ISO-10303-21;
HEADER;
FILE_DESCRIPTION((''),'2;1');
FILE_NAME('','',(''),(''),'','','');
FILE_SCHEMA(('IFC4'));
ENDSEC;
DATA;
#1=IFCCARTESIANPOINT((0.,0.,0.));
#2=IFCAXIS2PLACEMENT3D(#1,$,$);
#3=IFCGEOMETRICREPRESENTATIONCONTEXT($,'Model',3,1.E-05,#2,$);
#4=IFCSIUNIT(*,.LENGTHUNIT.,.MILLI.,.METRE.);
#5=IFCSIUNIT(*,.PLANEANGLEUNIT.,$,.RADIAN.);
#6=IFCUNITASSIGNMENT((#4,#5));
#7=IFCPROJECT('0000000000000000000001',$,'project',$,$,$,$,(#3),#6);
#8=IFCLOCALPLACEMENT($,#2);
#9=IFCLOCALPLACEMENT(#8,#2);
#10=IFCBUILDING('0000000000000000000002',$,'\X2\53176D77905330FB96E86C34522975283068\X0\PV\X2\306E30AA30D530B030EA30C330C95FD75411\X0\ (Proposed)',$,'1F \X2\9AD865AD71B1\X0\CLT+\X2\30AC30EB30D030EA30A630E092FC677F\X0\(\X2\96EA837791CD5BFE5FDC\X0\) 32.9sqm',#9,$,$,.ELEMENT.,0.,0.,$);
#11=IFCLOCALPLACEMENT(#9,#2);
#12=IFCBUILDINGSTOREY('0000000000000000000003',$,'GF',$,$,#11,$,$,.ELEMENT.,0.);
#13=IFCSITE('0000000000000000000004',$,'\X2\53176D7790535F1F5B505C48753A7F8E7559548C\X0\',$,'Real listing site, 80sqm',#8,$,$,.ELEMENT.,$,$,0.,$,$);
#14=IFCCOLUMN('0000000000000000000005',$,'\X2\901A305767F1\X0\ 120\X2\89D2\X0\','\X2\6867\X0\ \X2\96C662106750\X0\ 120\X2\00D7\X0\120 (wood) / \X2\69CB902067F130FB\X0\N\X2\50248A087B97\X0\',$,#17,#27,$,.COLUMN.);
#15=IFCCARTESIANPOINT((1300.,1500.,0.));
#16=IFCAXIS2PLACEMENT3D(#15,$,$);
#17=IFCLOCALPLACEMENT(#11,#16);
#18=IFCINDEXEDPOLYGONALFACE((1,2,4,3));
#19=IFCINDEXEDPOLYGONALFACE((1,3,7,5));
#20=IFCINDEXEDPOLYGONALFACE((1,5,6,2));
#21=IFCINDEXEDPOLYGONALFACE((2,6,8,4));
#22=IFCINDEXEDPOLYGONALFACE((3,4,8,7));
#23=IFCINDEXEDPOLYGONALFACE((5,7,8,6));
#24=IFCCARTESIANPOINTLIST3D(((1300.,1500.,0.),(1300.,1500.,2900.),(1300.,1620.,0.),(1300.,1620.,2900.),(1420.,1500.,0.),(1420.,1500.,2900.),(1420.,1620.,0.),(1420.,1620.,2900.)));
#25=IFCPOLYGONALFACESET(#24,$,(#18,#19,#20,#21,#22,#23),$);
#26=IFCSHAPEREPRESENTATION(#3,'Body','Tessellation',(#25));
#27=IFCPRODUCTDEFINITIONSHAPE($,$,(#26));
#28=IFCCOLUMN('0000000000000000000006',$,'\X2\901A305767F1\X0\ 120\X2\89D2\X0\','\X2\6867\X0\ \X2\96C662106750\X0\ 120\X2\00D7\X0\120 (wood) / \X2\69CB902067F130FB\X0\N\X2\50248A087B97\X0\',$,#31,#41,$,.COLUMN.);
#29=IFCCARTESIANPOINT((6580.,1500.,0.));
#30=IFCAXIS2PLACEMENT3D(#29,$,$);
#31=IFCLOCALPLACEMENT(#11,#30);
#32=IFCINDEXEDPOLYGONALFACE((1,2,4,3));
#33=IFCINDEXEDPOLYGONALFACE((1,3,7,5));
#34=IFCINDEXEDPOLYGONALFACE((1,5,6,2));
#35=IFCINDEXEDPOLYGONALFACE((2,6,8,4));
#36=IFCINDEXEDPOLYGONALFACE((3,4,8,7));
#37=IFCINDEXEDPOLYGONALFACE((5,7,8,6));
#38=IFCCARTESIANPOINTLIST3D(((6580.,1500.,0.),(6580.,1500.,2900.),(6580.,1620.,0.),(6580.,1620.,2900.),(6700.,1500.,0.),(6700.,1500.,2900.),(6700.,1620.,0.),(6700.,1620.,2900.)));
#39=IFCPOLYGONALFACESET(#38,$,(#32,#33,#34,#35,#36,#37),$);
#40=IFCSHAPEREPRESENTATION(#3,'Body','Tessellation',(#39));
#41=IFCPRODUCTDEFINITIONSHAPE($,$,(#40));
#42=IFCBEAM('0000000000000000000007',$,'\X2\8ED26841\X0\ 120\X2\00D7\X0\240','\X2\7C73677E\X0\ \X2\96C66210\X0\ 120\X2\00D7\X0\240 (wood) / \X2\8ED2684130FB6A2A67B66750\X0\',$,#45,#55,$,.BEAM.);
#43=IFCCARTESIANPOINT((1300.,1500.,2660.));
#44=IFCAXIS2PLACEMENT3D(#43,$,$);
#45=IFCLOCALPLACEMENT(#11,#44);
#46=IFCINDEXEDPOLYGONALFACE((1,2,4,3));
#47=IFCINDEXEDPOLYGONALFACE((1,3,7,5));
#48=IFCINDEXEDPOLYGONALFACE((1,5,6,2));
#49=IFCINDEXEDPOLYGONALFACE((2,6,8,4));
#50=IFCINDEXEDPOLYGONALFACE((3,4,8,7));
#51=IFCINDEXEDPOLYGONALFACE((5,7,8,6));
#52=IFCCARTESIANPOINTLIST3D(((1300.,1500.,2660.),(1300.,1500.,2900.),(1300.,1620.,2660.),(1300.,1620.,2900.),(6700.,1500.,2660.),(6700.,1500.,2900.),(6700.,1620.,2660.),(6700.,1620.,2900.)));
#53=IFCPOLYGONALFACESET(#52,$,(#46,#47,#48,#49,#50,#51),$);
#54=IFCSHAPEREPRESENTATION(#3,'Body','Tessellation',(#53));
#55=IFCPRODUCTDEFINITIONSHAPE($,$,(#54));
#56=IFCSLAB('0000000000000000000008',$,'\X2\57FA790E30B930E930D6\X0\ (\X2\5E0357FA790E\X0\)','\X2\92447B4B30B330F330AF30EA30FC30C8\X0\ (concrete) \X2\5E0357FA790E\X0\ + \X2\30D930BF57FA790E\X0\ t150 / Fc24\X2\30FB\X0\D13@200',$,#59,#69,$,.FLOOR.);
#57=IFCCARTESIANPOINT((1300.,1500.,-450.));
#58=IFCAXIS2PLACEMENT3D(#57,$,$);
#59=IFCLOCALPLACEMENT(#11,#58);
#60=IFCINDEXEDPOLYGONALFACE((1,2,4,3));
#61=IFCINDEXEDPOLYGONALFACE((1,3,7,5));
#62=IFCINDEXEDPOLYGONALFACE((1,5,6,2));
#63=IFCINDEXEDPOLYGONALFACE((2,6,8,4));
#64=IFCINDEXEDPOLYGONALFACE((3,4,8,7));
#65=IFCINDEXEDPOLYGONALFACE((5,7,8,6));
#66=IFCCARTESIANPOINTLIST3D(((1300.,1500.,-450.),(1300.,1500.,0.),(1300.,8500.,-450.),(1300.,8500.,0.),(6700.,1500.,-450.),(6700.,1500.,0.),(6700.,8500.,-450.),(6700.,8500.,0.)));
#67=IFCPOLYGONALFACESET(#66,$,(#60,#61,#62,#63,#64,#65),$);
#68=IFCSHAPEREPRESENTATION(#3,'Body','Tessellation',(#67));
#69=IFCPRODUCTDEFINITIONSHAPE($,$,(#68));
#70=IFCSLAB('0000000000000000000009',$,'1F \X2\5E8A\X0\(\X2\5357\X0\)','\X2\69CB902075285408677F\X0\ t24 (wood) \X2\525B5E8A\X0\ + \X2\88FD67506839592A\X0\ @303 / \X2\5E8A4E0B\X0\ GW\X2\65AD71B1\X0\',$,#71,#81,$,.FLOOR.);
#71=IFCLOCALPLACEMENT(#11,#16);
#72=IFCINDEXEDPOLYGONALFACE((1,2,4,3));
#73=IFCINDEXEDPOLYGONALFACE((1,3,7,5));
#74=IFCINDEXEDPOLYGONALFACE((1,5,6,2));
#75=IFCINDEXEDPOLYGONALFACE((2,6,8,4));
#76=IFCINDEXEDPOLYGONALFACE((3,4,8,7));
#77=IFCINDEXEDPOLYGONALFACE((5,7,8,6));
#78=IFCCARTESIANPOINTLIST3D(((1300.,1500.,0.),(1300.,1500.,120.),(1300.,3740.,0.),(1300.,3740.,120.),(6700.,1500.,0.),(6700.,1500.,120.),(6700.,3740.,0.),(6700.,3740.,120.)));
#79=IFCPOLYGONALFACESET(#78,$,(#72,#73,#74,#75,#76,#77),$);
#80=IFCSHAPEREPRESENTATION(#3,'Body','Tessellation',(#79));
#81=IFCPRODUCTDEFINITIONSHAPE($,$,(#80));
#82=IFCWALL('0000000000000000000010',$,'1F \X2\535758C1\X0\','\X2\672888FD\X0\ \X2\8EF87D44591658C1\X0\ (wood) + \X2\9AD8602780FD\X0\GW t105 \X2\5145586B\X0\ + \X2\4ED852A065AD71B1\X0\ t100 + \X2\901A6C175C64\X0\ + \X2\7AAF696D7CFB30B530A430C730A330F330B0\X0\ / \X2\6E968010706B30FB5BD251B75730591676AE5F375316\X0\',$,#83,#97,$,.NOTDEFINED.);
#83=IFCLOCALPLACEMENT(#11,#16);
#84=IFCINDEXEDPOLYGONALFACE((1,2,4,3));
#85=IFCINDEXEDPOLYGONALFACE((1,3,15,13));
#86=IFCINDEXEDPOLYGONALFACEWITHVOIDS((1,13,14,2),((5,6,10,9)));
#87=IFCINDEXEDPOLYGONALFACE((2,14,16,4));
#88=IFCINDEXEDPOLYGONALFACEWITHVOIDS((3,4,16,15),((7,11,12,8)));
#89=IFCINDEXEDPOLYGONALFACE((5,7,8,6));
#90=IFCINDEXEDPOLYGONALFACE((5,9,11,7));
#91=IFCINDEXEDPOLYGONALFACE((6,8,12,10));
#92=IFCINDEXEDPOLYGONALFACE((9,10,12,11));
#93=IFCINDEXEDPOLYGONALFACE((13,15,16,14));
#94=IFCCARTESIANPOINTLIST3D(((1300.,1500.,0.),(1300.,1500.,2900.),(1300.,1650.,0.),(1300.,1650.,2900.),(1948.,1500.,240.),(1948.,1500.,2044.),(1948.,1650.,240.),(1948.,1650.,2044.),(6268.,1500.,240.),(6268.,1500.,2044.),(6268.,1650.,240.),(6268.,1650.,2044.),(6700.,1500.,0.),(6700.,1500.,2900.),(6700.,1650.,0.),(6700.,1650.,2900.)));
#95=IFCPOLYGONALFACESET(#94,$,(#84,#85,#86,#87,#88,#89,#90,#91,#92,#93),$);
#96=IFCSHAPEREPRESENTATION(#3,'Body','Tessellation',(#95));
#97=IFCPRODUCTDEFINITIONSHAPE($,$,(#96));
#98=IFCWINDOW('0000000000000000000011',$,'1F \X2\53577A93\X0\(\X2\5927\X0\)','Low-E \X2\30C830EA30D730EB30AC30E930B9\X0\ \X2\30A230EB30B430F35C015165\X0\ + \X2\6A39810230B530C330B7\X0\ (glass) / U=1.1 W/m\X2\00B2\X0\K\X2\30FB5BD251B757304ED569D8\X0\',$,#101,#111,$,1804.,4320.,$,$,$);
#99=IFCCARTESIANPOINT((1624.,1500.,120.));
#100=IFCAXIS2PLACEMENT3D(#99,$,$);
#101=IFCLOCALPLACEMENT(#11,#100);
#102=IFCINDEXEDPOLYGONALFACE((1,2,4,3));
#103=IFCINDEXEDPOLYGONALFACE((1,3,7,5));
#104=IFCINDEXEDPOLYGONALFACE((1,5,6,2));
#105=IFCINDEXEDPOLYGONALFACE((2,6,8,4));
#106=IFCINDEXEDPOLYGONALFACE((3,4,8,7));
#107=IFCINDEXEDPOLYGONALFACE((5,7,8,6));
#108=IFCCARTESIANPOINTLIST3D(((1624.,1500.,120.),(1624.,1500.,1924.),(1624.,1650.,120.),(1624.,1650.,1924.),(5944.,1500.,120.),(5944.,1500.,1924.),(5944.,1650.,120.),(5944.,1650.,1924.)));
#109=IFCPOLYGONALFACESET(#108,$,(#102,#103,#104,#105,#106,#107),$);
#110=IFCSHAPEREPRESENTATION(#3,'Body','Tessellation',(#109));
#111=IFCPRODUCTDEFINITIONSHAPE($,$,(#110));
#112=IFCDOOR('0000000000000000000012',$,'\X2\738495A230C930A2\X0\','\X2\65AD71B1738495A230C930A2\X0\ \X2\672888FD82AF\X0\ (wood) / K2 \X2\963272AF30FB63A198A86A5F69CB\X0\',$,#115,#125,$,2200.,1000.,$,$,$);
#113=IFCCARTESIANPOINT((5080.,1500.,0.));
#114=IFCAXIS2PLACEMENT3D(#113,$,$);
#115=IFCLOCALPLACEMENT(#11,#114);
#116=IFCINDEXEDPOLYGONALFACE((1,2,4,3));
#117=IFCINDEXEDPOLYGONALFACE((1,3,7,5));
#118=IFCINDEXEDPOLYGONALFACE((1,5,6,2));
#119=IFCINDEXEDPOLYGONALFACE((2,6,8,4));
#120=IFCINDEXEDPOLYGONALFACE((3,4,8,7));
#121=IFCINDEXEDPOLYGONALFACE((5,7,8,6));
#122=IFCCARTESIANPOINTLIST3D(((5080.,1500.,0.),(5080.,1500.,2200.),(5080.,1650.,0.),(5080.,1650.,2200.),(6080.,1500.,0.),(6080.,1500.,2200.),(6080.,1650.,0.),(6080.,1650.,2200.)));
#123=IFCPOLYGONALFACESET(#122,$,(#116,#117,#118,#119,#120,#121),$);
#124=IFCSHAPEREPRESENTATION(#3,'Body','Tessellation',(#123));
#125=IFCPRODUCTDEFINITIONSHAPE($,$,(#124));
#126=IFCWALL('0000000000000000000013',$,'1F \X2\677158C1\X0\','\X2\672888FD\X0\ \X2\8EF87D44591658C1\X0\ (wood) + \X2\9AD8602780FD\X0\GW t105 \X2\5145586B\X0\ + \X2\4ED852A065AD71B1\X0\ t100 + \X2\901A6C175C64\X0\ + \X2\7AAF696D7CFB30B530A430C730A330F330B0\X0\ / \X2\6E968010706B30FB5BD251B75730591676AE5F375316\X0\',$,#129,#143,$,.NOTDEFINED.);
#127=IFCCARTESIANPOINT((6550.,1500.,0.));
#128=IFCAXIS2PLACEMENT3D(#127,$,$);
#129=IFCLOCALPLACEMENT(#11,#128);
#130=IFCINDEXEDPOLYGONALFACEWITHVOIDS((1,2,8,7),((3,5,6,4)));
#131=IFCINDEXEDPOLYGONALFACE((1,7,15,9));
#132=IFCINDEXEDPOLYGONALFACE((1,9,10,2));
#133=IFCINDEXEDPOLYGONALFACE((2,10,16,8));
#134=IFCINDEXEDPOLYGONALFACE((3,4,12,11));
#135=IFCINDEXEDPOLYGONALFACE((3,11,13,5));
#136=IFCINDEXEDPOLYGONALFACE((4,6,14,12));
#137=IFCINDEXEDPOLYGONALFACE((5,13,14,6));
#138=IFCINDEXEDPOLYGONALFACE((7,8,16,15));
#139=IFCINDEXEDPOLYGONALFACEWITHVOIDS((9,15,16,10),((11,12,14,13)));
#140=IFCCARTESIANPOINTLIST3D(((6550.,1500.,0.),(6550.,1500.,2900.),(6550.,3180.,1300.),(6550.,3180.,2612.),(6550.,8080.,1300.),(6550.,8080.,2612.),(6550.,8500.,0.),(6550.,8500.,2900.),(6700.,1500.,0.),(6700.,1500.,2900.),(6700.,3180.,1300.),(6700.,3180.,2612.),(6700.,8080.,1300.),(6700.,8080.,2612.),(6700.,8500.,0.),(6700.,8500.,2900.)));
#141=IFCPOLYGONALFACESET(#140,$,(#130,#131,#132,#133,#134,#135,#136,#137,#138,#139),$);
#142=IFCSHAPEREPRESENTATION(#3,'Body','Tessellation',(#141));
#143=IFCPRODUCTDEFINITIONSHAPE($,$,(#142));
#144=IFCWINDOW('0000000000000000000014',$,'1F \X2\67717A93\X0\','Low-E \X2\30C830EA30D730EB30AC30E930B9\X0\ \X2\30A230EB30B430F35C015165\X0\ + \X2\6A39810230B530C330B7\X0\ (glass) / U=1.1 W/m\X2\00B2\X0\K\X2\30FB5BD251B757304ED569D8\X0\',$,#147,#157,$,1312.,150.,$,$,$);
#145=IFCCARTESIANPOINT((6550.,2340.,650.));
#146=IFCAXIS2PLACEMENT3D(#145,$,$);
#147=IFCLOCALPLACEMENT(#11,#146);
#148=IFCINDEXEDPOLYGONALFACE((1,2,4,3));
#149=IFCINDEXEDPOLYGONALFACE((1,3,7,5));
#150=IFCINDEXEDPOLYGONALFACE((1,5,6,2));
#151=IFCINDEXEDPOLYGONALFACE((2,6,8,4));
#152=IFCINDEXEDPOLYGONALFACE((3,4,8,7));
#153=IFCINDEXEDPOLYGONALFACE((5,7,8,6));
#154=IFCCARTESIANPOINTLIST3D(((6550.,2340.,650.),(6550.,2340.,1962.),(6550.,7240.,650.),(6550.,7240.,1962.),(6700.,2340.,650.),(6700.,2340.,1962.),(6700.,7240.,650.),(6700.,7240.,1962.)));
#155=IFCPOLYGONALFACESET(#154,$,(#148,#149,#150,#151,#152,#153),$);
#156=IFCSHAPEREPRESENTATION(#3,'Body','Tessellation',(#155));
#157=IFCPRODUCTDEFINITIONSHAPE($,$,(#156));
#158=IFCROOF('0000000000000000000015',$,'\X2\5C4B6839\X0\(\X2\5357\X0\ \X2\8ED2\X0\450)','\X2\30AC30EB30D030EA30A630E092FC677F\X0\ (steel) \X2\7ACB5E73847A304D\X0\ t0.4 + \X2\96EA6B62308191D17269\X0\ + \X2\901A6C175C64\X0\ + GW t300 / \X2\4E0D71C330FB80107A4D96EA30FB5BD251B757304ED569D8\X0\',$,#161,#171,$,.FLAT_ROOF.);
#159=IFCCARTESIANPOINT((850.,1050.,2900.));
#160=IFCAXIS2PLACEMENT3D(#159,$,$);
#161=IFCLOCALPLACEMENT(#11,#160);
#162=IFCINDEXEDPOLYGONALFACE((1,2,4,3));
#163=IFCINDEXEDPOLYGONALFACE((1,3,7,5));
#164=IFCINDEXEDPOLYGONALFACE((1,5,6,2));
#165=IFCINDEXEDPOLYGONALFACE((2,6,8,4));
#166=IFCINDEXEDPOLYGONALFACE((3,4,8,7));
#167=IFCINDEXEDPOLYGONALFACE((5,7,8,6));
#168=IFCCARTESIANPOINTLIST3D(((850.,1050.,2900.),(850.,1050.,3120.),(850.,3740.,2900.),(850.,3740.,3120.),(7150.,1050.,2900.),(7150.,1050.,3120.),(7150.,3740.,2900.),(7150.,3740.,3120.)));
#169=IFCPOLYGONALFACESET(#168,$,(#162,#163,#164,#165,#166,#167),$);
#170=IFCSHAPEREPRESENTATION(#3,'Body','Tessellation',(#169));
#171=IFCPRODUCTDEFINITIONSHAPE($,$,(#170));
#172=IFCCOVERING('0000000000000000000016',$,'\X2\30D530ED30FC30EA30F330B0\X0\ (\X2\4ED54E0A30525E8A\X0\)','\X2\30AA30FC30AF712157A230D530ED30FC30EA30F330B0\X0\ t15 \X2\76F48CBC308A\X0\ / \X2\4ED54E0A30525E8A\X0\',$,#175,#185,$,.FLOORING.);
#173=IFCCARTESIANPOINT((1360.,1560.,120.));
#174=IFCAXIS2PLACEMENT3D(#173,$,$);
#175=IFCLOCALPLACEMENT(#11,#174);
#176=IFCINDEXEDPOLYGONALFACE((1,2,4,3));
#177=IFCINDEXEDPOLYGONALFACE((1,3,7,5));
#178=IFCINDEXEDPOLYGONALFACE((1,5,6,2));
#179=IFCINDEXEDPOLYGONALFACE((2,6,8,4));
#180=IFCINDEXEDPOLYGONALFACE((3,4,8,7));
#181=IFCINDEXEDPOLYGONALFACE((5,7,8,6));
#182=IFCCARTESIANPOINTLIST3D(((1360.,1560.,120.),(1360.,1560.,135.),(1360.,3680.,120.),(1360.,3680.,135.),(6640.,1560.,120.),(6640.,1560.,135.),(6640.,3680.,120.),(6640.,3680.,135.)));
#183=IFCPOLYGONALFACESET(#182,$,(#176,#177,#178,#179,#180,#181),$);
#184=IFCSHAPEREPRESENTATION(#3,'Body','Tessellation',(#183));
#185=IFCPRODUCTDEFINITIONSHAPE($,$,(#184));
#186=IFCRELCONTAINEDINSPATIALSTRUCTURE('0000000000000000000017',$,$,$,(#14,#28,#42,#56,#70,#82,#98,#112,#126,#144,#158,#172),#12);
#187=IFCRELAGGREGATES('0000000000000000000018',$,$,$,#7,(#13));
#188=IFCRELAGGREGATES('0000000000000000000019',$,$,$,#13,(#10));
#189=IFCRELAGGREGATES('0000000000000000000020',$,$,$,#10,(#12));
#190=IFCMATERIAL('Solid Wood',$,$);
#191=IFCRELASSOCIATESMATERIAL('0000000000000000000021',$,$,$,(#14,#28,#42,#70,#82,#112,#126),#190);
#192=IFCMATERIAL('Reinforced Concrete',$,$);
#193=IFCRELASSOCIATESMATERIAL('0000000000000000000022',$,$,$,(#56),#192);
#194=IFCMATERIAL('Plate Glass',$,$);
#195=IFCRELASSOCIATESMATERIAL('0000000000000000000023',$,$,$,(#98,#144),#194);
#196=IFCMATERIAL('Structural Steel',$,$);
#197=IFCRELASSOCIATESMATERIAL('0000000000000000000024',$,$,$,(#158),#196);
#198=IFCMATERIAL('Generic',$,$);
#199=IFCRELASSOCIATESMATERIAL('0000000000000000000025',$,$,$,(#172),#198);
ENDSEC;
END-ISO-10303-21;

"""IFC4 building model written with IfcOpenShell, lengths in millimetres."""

from ifc_helpers import new_model, si_unit, frame, frame_2d, origin, place, context, project, spatial, rectangle, extrude, material, element, fill, save


model = new_model("IFC4")

# Units and contexts
model_context = context("Model", 3, precision=1e-05, world=origin())
ifc_project = project(units=[si_unit("LENGTHUNIT", "METRE", prefix="MILLI"), si_unit("PLANEANGLEUNIT", "RADIAN")], contexts=[model_context])

# Site, building, storey
site_placement = place(None, origin())
site = spatial("IfcSite", under=ifc_project, at=site_placement, Name="北海道弟子屈町美留和", ObjectType="Real listing site, 80sqm", CompositionType="ELEMENT", RefElevation=0.0)
building_placement = place(site_placement, origin())
building = spatial("IfcBuilding", under=site, at=building_placement, Name="北海道・雨水利用とPVのオフグリッド志向 (Proposed)", ObjectType="1F 高断熱CLT+ガルバリウム鋼板(雪荷重対応) 32.9sqm", CompositionType="ELEMENT", ElevationOfRefHeight=0.0, ElevationOfTerrain=0.0)
storey_placement = place(building_placement, origin())
storey = spatial("IfcBuildingStorey", under=building, at=storey_placement, Name="GF", CompositionType="ELEMENT", Elevation=0.0)

# Columns
ifc_material_1 = material(Name="Solid Wood")
column_1_placement = place(storey_placement, frame((1300.0, 1500.0, 0.0)))
element("IfcColumn", 1, at=column_1_placement, inside=storey, material=ifc_material_1, Name="通し柱 120角", Description="桧 集成材 120×120 (wood) / 構造柱・N値計算", PredefinedType="COLUMN", context=model_context, shape_type="SweptSolid", body=[
    extrude(rectangle(XDim=120.0, YDim=120.0, at=frame_2d((60.0, 60.0))), frame((1300.0, 1500.0, 0.0)), (0.0, 0.0, 1.0), 2900.0),
])
column_2_placement = place(storey_placement, frame((6580.0, 1500.0, 0.0)))
element("IfcColumn", 2, at=column_2_placement, inside=storey, material=ifc_material_1, Name="通し柱 120角", Description="桧 集成材 120×120 (wood) / 構造柱・N値計算", PredefinedType="COLUMN", context=model_context, shape_type="SweptSolid", body=[
    extrude(rectangle(XDim=120.0, YDim=120.0, at=frame_2d((60.0, 60.0))), frame((6580.0, 1500.0, 0.0)), (0.0, 0.0, 1.0), 2900.0),
])

# Beam
beam_1_placement = place(storey_placement, frame((1300.0, 1500.0, 2660.0)))
element("IfcBeam", 3, at=beam_1_placement, inside=storey, material=ifc_material_1, Name="軒桁 120×240", Description="米松 集成 120×240 (wood) / 軒桁・横架材", PredefinedType="BEAM", context=model_context, shape_type="SweptSolid", body=[
    extrude(rectangle(XDim=5400.0, YDim=120.0, at=frame_2d((2700.0, 60.0))), frame((1300.0, 1500.0, 2660.0)), (0.0, 0.0, 1.0), 240.0),
])

# Slabs
ifc_material_2 = material(Name="Reinforced Concrete")
slab_1_placement = place(storey_placement, frame((1300.0, 1500.0, -450.0)))
element("IfcSlab", 4, at=slab_1_placement, inside=storey, material=ifc_material_2, Name="基礎スラブ (布基礎)", Description="鉄筋コンクリート (concrete) 布基礎 + ベタ基礎 t150 / Fc24・D13@200", PredefinedType="FLOOR", context=model_context, shape_type="SweptSolid", body=[
    extrude(rectangle(XDim=5400.0, YDim=7000.0, at=frame_2d((2700.0, 3500.0))), frame((1300.0, 1500.0, -450.0)), (0.0, 0.0, 1.0), 450.0),
])
slab_2_placement = place(storey_placement, frame((1300.0, 1500.0, 0.0)))
element("IfcSlab", 5, at=slab_2_placement, inside=storey, material=ifc_material_1, Name="1F 床(南)", Description="構造用合板 t24 (wood) 剛床 + 製材根太 @303 / 床下 GW断熱", PredefinedType="FLOOR", context=model_context, shape_type="SweptSolid", body=[
    extrude(rectangle(XDim=5400.0, YDim=2240.0, at=frame_2d((2700.0, 1120.0))), frame((1300.0, 1500.0, 0.0)), (0.0, 0.0, 1.0), 120.0),
])

# Wall, openings, window, door
wall_1_placement = place(storey_placement, frame((1300.0, 1500.0, 0.0)))
wall_1 = element("IfcWall", 6, at=wall_1_placement, inside=storey, material=ifc_material_1, Name="1F 南壁", Description="木製 軸組外壁 (wood) + 高性能GW t105 充填 + 付加断熱 t100 + 通気層 + 窯業系サイディング / 準耐火・寒冷地外皮強化", PredefinedType="NOTDEFINED", context=model_context, shape_type="SweptSolid", body=[
    extrude(rectangle(XDim=5400.0, YDim=150.0, at=frame_2d((2700.0, 75.0))), frame((1300.0, 1500.0, 0.0)), (0.0, 0.0, 1.0), 2900.0),
])
opening_1_placement = place(storey_placement, frame((1624.0, 1500.0, 120.0)))
opening_1 = element("IfcOpeningElement", 7, at=opening_1_placement, cuts=wall_1, PredefinedType="NOTDEFINED", context=model_context, shape_type="SweptSolid", body=[
    extrude(rectangle(XDim=4320.0, YDim=150.0, at=frame_2d((2160.0, 75.0))), frame((1624.0, 1500.0, 120.0)), (0.0, 0.0, 1.0), 1804.0),
])
opening_2_placement = place(storey_placement, frame((5080.0, 1500.0, 0.0)))
opening_2 = element("IfcOpeningElement", 8, at=opening_2_placement, cuts=wall_1, PredefinedType="NOTDEFINED", context=model_context, shape_type="SweptSolid", body=[
    extrude(rectangle(XDim=1000.0, YDim=150.0, at=frame_2d((500.0, 75.0))), frame((5080.0, 1500.0, 0.0)), (0.0, 0.0, 1.0), 2200.0),
])
ifc_material_3 = material(Name="Plate Glass")
window_1_placement = place(storey_placement, frame((1624.0, 1500.0, 120.0)))
window_1 = element("IfcWindow", 9, at=window_1_placement, inside=storey, material=ifc_material_3, Name="1F 南窓(大)", Description="Low-E トリプルガラス アルゴン封入 + 樹脂サッシ (glass) / U=1.1 W/m²K・寒冷地仕様", OverallHeight=1804.0, OverallWidth=4320.0, context=model_context, shape_type="SweptSolid", body=[
    extrude(rectangle(XDim=4320.0, YDim=150.0, at=frame_2d((2160.0, 75.0))), frame((1624.0, 1500.0, 120.0)), (0.0, 0.0, 1.0), 1804.0),
])
fill(opening_1, window_1)
door_placement = place(storey_placement, frame((5080.0, 1500.0, 0.0)))
door = element("IfcDoor", 10, at=door_placement, inside=storey, material=ifc_material_1, Name="玄関ドア", Description="断熱玄関ドア 木製芯 (wood) / K2 防犯・採風機構", OverallHeight=2200.0, OverallWidth=1000.0, context=model_context, shape_type="SweptSolid", body=[
    extrude(rectangle(XDim=1000.0, YDim=150.0, at=frame_2d((500.0, 75.0))), frame((5080.0, 1500.0, 0.0)), (0.0, 0.0, 1.0), 2200.0),
])
fill(opening_2, door)

# Wall, opening, window
wall_2_placement = place(storey_placement, frame((6550.0, 1500.0, 0.0)))
wall_2 = element("IfcWall", 11, at=wall_2_placement, inside=storey, material=ifc_material_1, Name="1F 東壁", Description="木製 軸組外壁 (wood) + 高性能GW t105 充填 + 付加断熱 t100 + 通気層 + 窯業系サイディング / 準耐火・寒冷地外皮強化", PredefinedType="NOTDEFINED", context=model_context, shape_type="SweptSolid", body=[
    extrude(rectangle(XDim=150.0, YDim=7000.0, at=frame_2d((75.0, 3500.0))), frame((6550.0, 1500.0, 0.0)), (0.0, 0.0, 1.0), 2900.0),
])
opening_3_placement = place(storey_placement, frame((6550.0, 2340.0, 650.0)))
opening_3 = element("IfcOpeningElement", 12, at=opening_3_placement, cuts=wall_2, PredefinedType="NOTDEFINED", context=model_context, shape_type="SweptSolid", body=[
    extrude(rectangle(XDim=150.0, YDim=4900.0, at=frame_2d((75.0, 2450.0))), frame((6550.0, 2340.0, 650.0)), (0.0, 0.0, 1.0), 1312.0),
])
window_2_placement = place(storey_placement, frame((6550.0, 2340.0, 650.0)))
window_2 = element("IfcWindow", 13, at=window_2_placement, inside=storey, material=ifc_material_3, Name="1F 東窓", Description="Low-E トリプルガラス アルゴン封入 + 樹脂サッシ (glass) / U=1.1 W/m²K・寒冷地仕様", OverallHeight=1312.0, OverallWidth=150.0, context=model_context, shape_type="SweptSolid", body=[
    extrude(rectangle(XDim=150.0, YDim=4900.0, at=frame_2d((75.0, 2450.0))), frame((6550.0, 2340.0, 650.0)), (0.0, 0.0, 1.0), 1312.0),
])
fill(opening_3, window_2)

# Roof
ifc_material_4 = material(Name="Structural Steel")
roof_placement = place(storey_placement, frame((850.0, 1050.0, 2900.0)))
element("IfcRoof", 14, at=roof_placement, inside=storey, material=ifc_material_4, Name="屋根(南 軒450)", Description="ガルバリウム鋼板 (steel) 立平葺き t0.4 + 雪止め金物 + 通気層 + GW t300 / 不燃・耐積雪・寒冷地仕様", PredefinedType="FLAT_ROOF", context=model_context, shape_type="SweptSolid", body=[
    extrude(rectangle(XDim=6300.0, YDim=2690.0, at=frame_2d((3150.0, 1345.0))), frame((850.0, 1050.0, 2900.0)), (0.0, 0.0, 1.0), 220.0),
])

# Covering
ifc_material_5 = material(Name="Generic")
covering_1_placement = place(storey_placement, frame((1360.0, 1560.0, 120.0)))
element("IfcCovering", 15, at=covering_1_placement, inside=storey, material=ifc_material_5, Name="フローリング (仕上げ床)", Description="オーク無垢フローリング t15 直貼り / 仕上げ床", PredefinedType="FLOORING", context=model_context, shape_type="SweptSolid", body=[
    extrude(rectangle(XDim=5280.0, YDim=2120.0, at=frame_2d((2640.0, 1060.0))), frame((1360.0, 1560.0, 120.0)), (0.0, 0.0, 1.0), 15.0),
])

save(model, "model.ifc")
